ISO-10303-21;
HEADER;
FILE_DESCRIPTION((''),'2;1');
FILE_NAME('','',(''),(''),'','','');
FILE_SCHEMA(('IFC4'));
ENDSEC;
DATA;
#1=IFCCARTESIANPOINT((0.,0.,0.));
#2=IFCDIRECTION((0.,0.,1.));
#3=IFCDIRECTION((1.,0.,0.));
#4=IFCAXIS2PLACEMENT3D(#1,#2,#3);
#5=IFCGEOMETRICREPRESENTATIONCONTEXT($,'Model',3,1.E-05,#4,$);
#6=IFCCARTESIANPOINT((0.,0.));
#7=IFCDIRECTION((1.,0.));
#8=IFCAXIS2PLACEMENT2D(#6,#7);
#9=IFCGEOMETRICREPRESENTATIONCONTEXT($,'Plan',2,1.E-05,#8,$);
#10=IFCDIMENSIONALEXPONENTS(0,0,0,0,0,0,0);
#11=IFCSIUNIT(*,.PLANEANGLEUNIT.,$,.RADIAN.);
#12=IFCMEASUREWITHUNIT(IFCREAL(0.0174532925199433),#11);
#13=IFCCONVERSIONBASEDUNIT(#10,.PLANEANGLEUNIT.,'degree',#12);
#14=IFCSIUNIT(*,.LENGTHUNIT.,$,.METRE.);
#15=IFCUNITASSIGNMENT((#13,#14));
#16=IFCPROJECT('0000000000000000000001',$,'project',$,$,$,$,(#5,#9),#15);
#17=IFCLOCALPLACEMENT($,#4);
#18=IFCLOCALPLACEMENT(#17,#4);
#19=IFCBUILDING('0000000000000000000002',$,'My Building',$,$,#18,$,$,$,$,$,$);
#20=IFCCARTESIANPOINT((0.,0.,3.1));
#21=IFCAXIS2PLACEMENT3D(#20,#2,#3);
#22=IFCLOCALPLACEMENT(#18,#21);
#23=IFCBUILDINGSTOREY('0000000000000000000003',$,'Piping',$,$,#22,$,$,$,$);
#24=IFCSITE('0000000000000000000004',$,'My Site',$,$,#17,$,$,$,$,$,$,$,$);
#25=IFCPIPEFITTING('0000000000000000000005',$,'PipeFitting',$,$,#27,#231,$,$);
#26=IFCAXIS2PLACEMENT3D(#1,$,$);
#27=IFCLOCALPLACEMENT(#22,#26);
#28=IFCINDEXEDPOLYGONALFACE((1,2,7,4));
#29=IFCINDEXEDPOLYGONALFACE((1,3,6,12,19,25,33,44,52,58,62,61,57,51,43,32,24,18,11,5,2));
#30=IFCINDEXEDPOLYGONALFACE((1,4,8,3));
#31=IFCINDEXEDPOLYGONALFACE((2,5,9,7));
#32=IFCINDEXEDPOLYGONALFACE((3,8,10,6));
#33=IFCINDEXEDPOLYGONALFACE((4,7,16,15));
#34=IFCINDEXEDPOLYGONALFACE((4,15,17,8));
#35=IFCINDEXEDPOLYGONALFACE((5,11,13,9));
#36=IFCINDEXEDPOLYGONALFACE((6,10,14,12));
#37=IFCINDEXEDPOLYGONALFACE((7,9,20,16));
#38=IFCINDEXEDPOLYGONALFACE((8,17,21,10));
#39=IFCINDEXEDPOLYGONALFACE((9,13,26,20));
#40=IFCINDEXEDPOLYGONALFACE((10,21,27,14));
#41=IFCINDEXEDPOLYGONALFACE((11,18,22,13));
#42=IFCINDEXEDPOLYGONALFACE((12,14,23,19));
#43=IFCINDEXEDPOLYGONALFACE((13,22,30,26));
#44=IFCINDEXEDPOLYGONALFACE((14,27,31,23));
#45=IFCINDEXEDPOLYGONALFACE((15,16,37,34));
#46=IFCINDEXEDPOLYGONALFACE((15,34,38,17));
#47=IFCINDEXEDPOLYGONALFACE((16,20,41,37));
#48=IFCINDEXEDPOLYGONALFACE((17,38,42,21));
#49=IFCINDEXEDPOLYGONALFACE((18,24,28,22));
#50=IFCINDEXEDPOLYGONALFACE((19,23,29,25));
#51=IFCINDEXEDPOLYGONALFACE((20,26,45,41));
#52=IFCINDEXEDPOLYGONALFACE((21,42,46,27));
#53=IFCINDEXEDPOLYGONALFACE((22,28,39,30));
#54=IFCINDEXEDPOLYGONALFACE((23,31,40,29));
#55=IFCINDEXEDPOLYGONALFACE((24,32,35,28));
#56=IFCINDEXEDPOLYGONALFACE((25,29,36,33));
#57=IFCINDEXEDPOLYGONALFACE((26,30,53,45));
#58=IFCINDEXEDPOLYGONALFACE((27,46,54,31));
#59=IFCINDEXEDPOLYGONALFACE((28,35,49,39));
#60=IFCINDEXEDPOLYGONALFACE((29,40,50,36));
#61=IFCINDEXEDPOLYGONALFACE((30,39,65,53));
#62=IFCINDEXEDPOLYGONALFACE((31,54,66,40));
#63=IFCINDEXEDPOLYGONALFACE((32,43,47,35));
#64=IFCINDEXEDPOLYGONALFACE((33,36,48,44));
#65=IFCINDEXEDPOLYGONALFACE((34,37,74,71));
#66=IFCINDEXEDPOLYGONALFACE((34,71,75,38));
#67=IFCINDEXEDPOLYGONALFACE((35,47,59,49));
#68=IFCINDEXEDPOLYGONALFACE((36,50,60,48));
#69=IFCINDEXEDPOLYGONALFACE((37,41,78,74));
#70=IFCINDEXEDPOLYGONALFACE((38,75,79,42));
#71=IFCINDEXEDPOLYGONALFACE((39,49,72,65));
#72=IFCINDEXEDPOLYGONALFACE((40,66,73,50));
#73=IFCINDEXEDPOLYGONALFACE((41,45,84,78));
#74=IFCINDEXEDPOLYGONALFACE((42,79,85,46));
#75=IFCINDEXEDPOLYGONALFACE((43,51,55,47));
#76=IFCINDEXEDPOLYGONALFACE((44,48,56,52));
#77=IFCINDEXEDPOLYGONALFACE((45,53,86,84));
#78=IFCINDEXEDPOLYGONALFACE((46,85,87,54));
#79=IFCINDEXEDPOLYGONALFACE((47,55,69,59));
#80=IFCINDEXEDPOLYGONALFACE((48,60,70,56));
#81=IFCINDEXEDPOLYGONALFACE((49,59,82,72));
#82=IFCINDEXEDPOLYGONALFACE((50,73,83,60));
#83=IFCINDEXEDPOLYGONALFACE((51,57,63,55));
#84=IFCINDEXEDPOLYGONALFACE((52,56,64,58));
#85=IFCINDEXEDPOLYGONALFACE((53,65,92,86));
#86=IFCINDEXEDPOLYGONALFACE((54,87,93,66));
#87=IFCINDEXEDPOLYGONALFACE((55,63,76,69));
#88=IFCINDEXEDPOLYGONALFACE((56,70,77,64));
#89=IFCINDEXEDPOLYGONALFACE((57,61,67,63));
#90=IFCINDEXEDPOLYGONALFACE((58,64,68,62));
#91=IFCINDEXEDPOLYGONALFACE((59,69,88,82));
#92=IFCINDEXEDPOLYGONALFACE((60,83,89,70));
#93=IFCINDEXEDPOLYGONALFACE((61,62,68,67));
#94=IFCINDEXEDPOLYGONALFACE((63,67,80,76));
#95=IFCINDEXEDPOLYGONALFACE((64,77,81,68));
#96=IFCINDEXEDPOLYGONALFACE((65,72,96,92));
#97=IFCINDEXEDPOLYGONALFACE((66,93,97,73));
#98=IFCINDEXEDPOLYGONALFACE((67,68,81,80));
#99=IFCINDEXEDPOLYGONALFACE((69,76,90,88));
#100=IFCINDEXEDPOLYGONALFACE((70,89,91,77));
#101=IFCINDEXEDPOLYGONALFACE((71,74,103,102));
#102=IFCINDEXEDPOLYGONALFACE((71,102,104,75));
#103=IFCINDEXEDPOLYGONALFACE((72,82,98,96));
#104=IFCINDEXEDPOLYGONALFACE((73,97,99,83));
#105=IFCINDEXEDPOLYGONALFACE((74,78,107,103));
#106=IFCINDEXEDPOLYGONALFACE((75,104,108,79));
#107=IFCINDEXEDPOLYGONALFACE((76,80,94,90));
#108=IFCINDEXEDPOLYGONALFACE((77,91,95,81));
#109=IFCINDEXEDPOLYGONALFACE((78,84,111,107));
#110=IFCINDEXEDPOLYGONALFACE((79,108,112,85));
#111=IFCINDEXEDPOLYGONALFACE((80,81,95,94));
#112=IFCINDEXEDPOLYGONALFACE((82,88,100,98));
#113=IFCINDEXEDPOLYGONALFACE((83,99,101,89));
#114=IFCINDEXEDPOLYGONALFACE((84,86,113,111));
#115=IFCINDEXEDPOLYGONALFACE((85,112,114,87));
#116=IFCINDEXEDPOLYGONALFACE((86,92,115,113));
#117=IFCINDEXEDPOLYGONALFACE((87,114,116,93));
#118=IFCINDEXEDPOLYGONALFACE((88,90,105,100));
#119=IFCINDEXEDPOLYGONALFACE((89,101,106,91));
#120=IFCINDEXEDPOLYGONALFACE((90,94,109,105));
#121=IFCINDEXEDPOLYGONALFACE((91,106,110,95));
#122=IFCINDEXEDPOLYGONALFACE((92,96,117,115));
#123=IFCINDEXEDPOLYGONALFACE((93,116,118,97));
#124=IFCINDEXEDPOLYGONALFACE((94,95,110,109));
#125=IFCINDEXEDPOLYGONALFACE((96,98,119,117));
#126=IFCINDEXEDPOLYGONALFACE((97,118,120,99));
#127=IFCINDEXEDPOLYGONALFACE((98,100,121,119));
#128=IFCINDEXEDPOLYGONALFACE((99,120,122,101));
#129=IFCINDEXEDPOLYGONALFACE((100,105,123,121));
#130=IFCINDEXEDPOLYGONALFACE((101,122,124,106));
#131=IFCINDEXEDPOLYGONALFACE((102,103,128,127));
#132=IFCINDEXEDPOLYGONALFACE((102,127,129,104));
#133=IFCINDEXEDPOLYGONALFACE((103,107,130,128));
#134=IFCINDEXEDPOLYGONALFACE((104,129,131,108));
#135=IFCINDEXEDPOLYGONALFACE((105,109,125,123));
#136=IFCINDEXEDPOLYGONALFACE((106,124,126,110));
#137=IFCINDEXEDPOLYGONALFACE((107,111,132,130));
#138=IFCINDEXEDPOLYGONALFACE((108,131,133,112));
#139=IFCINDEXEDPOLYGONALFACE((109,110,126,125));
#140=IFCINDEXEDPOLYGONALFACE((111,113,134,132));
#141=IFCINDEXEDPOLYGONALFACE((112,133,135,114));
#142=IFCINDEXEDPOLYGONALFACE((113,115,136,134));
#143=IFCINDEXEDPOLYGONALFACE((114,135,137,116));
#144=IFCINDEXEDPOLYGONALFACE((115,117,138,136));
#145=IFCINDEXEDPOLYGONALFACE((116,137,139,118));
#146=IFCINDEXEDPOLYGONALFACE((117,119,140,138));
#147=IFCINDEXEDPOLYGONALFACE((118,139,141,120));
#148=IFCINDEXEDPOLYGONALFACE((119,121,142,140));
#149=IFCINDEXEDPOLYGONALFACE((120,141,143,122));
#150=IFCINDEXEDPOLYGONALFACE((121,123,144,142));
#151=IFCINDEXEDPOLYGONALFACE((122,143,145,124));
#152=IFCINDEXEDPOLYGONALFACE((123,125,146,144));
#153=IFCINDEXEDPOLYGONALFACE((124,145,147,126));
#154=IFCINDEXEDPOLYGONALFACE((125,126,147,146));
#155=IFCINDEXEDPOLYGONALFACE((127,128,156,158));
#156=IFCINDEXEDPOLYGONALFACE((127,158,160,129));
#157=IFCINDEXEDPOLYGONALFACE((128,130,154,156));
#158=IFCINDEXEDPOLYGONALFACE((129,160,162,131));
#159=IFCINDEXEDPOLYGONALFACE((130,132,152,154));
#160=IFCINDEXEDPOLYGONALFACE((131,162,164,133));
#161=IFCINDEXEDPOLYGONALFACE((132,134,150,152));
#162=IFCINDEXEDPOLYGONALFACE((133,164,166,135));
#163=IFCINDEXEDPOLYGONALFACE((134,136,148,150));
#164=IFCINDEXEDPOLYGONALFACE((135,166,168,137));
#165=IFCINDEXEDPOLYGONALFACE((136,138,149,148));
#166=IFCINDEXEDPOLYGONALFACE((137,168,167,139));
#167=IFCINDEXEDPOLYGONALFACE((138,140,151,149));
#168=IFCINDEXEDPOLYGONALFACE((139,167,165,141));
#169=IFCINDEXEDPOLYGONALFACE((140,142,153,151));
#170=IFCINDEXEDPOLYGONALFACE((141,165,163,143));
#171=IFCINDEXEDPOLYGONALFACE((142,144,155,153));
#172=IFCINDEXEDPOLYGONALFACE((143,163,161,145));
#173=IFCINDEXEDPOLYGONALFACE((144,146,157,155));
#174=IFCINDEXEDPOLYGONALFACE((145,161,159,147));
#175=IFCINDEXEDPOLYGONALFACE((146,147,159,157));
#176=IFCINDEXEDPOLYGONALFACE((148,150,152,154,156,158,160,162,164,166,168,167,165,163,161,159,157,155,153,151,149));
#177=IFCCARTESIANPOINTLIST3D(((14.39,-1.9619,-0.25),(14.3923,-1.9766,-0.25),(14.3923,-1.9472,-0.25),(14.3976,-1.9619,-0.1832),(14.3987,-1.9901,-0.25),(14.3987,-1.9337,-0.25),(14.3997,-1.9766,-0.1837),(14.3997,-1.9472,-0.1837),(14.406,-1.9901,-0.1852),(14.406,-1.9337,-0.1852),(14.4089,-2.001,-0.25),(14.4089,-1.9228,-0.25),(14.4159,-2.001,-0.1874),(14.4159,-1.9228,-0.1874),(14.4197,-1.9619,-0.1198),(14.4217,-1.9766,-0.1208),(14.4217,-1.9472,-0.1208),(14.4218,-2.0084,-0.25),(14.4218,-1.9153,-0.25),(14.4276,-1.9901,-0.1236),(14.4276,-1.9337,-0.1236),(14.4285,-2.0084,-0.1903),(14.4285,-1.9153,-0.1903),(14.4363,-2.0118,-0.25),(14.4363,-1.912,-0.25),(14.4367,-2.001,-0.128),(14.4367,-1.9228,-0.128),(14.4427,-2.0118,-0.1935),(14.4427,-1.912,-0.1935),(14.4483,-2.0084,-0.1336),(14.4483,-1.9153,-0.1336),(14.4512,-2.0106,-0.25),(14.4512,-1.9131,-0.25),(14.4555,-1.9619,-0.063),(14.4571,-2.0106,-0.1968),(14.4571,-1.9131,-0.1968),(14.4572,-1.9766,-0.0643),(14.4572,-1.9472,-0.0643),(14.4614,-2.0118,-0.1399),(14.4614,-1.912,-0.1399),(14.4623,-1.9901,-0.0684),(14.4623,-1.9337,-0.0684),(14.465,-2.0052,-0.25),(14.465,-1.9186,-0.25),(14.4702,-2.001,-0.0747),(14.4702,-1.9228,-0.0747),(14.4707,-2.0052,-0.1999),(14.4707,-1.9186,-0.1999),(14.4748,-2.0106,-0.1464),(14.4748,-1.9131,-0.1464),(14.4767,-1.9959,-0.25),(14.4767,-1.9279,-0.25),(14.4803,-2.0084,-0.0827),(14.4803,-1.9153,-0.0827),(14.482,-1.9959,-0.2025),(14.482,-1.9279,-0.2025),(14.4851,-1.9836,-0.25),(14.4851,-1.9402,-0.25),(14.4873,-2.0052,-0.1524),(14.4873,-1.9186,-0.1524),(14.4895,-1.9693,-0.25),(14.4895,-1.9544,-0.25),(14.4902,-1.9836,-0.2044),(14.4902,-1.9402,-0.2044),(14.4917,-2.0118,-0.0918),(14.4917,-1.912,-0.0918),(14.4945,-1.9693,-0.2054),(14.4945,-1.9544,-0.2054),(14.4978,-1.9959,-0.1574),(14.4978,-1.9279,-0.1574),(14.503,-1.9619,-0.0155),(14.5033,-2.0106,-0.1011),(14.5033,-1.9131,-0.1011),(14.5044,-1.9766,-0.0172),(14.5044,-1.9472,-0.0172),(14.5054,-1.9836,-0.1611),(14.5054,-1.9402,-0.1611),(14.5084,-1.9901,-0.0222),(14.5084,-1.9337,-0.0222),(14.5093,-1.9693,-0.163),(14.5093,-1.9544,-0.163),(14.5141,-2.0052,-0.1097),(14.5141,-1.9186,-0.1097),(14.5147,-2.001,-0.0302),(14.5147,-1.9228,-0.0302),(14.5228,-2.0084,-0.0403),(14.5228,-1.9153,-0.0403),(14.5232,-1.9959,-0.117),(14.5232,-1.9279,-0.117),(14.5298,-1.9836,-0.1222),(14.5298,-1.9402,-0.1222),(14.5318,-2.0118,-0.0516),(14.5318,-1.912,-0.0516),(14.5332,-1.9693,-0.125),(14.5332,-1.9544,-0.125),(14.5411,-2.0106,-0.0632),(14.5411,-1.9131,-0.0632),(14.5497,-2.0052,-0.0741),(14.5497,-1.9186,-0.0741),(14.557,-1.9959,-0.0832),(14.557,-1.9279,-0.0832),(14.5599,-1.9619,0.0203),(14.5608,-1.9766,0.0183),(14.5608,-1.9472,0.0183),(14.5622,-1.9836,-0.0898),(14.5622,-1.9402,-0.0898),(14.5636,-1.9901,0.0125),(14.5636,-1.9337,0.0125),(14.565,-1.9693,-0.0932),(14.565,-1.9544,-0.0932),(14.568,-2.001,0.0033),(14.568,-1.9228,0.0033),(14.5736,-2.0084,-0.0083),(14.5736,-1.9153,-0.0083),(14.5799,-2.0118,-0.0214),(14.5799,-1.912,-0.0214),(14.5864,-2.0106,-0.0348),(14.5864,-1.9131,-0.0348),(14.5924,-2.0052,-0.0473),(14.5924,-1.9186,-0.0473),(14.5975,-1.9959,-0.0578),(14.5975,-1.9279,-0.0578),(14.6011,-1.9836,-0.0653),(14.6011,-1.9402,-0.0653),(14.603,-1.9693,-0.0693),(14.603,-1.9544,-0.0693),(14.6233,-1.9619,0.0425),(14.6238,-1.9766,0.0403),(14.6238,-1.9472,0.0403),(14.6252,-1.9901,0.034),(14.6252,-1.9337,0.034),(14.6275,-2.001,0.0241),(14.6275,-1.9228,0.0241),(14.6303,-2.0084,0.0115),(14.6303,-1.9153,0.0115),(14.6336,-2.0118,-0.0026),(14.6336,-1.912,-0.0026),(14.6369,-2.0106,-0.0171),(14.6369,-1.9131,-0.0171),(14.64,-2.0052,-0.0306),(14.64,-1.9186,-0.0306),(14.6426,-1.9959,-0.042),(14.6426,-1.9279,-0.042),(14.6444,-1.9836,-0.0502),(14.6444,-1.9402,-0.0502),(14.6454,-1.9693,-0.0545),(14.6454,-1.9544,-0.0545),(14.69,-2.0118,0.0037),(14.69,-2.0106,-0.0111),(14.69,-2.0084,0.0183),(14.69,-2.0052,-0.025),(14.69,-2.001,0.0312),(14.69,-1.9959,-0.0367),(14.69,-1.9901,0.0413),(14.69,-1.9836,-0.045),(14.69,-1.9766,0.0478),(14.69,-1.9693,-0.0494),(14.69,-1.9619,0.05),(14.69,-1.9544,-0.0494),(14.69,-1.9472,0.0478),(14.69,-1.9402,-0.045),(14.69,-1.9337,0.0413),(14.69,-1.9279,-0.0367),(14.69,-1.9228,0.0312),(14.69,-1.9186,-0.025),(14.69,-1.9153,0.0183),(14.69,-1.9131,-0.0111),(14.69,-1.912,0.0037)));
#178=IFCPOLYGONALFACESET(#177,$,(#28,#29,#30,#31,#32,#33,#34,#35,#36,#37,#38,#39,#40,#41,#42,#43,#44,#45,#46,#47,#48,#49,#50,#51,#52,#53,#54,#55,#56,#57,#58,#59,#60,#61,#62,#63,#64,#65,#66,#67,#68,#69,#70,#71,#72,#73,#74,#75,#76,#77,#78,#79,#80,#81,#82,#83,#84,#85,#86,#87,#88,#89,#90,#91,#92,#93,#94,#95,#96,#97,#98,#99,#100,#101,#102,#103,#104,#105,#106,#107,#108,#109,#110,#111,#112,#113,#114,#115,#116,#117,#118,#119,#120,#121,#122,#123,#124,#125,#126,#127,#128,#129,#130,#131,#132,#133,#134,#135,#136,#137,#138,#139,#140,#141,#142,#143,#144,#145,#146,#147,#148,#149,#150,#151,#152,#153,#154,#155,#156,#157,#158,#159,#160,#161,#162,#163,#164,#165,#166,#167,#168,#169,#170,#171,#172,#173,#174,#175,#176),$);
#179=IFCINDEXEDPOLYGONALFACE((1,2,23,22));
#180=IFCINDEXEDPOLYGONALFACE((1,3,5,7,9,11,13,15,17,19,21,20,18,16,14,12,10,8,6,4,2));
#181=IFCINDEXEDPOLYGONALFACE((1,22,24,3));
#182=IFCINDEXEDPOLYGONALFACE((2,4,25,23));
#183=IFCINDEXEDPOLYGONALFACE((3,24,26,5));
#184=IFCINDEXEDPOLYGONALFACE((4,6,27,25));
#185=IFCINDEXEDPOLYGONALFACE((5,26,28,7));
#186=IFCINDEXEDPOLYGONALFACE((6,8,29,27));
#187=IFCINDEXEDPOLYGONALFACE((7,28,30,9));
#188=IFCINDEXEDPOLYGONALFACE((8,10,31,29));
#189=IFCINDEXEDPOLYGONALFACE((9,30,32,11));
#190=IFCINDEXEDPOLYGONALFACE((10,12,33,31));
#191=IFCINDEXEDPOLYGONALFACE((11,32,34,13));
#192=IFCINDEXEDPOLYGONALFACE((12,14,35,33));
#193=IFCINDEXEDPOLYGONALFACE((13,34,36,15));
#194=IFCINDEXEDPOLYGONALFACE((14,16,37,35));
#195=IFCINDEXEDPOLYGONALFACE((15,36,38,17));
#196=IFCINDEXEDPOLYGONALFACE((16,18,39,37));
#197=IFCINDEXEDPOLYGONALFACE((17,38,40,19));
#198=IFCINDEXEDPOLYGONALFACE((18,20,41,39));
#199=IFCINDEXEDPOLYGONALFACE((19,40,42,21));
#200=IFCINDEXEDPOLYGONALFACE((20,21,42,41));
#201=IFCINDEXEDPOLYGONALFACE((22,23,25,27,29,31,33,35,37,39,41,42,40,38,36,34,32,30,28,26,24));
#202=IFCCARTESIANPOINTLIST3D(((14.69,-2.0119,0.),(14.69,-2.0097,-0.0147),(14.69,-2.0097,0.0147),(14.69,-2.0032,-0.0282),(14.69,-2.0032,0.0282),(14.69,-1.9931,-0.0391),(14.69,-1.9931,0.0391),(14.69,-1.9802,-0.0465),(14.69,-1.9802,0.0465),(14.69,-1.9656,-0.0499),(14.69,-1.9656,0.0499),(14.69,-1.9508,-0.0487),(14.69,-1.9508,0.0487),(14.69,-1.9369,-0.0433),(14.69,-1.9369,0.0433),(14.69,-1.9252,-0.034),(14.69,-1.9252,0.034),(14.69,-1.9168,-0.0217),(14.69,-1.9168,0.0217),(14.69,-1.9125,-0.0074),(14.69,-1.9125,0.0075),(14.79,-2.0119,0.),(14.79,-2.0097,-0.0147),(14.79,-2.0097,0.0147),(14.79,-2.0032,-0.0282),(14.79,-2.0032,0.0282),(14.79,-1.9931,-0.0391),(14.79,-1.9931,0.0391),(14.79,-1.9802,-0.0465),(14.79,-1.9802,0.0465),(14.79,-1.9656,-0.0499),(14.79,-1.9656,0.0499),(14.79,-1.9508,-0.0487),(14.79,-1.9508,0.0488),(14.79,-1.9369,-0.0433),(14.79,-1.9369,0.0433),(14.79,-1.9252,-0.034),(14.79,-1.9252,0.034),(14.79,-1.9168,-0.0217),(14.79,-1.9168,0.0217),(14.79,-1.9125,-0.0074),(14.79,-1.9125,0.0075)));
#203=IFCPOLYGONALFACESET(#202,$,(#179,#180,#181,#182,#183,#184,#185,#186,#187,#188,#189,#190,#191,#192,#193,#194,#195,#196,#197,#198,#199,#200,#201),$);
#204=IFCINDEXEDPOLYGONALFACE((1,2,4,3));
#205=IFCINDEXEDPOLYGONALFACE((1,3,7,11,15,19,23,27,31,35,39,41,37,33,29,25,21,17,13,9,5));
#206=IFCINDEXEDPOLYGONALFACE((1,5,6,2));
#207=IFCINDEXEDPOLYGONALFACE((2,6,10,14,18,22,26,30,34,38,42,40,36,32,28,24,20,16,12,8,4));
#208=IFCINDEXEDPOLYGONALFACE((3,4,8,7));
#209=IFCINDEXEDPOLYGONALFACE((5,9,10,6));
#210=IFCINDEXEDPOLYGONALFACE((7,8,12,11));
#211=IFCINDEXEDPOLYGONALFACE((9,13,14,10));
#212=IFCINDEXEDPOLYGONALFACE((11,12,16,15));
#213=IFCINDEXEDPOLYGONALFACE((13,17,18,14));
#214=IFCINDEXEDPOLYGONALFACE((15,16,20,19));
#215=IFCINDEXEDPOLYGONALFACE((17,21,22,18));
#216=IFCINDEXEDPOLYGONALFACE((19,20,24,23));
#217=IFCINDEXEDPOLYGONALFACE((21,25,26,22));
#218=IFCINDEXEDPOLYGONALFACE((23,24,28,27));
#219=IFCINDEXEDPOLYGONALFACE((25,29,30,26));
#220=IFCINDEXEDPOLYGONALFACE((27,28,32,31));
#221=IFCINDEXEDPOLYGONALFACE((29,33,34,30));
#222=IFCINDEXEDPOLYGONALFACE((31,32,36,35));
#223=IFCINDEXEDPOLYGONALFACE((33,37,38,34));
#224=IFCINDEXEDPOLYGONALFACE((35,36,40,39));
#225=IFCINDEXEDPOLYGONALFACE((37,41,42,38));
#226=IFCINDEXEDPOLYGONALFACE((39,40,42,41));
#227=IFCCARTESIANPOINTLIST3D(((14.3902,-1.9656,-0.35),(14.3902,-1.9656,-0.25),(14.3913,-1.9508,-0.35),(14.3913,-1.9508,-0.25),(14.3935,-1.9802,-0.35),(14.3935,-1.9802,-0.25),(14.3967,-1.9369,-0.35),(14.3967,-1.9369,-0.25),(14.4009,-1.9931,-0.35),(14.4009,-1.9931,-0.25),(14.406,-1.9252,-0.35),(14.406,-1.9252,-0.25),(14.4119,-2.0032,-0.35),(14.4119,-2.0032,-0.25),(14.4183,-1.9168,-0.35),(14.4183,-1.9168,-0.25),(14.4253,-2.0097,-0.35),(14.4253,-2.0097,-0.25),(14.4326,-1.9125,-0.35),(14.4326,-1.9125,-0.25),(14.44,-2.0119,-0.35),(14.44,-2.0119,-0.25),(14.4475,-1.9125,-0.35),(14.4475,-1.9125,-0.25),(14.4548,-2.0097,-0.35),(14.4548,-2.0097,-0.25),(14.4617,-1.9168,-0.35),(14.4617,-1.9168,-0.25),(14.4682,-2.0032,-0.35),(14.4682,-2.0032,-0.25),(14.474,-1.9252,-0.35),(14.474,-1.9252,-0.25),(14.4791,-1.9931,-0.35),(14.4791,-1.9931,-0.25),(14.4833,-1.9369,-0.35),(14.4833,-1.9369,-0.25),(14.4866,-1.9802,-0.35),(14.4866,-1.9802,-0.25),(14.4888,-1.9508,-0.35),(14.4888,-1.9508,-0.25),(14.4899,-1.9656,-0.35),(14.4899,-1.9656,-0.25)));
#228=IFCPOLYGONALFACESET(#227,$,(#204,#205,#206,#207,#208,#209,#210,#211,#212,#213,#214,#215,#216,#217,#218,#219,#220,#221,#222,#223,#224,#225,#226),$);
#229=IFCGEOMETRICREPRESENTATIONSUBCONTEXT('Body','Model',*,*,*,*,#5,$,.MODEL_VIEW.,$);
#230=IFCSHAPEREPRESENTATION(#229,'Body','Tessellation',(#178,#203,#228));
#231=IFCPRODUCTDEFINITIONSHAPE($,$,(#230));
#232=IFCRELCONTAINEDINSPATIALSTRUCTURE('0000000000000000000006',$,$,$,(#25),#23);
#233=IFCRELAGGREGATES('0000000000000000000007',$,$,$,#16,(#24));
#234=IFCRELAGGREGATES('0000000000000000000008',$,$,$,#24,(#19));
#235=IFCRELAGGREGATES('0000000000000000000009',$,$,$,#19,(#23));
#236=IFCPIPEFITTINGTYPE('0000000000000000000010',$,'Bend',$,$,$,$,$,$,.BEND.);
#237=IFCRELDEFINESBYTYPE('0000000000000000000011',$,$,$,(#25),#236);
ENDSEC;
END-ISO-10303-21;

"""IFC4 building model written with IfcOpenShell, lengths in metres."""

from ifc_helpers import new_model, entity, si_unit, converted_unit, frame, origin_with_axes, origin_2d_with_axis, place, context, subcontext, project, spatial, circle, extrude, source, transform, mapped, type_object, type_shapes, element, save


model = new_model("IFC4")

# Units and contexts
model_context = context("Model", 3, precision=1e-05, world=origin_with_axes())
plan_context = context("Plan", 2, precision=1e-05, world=origin_2d_with_axis())
body_context = subcontext(model_context, "Body", "Model", "MODEL_VIEW")
ifc_project = project(units=[converted_unit("PLANEANGLEUNIT", "degree", entity("IfcReal", 0.0174532925199433), si_unit("PLANEANGLEUNIT", "RADIAN"), dimensions=[0, 0, 0, 0, 0, 0, 0]), si_unit("LENGTHUNIT", "METRE")], contexts=[model_context, plan_context])

# Site, building, storey
site_placement = place(None, origin_with_axes())
site = spatial("IfcSite", under=ifc_project, at=site_placement, Name="My Site")
building_placement = place(site_placement, origin_with_axes())
building = spatial("IfcBuilding", under=site, at=building_placement, Name="My Building")
storey_placement = place(building_placement, frame((0.0, 0.0, 3.1), z_axis=(0.0, 0.0, 1.0), x_axis=(1.0, 0.0, 0.0)))
storey = spatial("IfcBuildingStorey", under=building, at=storey_placement, Name="Piping")

# Pipe fitting
pipe_fitting_type_1 = type_object("IfcPipeFittingType", Name="Bend", PredefinedType="BEND")
shared_shape_1 = source(origin_with_axes(), body_context, "Body", "SolidModel", [
    entity("IfcSweptDiskSolid", entity("IfcIndexedPolyCurve", entity("IfcCartesianPointList3D", [[0.0, 0.0, 0.1], [0.0, -0.0732, 0.2768], [0.0, -0.25, 0.35]]), [entity("IfcArcIndex", [1, 2, 3])]), 0.05),
    extrude(circle(Radius=0.05), origin_with_axes(), (0.0, 0.0, 1.0), 0.1),
    extrude(circle(Radius=0.05), frame((0.0, -0.25, 0.35), z_axis=(0.0, -1.0, 0.000022), x_axis=(1.0, 0.0, 0.0)), (0.0, 0.0, 1.0), 0.1),
])
type_shapes(pipe_fitting_type_1, [shared_shape_1])
for number, where, z_axis, x_axis, name in (
    (1, (14.79, -1.9619, 0.0), (-1.0, 0.0, -0.000022), (0.0, -1.0, 0.0), "PipeFitting"),
):
    element("IfcPipeFitting", number, at=place(storey_placement, frame(where, z_axis=z_axis, x_axis=x_axis)), inside=storey, type_object=pipe_fitting_type_1, Name=name, context=body_context, shape_type="MappedRepresentation", body=[
        mapped(shared_shape_1, transform((0.0, 0.0, 0.0), x_axis=(1.0, 0.0, 0.0), y_axis=(0.0, 1.0, 0.0), z_axis=(0.0, 0.0, 1.0), scale=1.0)),
    ])

save(model, "model.ifc")
